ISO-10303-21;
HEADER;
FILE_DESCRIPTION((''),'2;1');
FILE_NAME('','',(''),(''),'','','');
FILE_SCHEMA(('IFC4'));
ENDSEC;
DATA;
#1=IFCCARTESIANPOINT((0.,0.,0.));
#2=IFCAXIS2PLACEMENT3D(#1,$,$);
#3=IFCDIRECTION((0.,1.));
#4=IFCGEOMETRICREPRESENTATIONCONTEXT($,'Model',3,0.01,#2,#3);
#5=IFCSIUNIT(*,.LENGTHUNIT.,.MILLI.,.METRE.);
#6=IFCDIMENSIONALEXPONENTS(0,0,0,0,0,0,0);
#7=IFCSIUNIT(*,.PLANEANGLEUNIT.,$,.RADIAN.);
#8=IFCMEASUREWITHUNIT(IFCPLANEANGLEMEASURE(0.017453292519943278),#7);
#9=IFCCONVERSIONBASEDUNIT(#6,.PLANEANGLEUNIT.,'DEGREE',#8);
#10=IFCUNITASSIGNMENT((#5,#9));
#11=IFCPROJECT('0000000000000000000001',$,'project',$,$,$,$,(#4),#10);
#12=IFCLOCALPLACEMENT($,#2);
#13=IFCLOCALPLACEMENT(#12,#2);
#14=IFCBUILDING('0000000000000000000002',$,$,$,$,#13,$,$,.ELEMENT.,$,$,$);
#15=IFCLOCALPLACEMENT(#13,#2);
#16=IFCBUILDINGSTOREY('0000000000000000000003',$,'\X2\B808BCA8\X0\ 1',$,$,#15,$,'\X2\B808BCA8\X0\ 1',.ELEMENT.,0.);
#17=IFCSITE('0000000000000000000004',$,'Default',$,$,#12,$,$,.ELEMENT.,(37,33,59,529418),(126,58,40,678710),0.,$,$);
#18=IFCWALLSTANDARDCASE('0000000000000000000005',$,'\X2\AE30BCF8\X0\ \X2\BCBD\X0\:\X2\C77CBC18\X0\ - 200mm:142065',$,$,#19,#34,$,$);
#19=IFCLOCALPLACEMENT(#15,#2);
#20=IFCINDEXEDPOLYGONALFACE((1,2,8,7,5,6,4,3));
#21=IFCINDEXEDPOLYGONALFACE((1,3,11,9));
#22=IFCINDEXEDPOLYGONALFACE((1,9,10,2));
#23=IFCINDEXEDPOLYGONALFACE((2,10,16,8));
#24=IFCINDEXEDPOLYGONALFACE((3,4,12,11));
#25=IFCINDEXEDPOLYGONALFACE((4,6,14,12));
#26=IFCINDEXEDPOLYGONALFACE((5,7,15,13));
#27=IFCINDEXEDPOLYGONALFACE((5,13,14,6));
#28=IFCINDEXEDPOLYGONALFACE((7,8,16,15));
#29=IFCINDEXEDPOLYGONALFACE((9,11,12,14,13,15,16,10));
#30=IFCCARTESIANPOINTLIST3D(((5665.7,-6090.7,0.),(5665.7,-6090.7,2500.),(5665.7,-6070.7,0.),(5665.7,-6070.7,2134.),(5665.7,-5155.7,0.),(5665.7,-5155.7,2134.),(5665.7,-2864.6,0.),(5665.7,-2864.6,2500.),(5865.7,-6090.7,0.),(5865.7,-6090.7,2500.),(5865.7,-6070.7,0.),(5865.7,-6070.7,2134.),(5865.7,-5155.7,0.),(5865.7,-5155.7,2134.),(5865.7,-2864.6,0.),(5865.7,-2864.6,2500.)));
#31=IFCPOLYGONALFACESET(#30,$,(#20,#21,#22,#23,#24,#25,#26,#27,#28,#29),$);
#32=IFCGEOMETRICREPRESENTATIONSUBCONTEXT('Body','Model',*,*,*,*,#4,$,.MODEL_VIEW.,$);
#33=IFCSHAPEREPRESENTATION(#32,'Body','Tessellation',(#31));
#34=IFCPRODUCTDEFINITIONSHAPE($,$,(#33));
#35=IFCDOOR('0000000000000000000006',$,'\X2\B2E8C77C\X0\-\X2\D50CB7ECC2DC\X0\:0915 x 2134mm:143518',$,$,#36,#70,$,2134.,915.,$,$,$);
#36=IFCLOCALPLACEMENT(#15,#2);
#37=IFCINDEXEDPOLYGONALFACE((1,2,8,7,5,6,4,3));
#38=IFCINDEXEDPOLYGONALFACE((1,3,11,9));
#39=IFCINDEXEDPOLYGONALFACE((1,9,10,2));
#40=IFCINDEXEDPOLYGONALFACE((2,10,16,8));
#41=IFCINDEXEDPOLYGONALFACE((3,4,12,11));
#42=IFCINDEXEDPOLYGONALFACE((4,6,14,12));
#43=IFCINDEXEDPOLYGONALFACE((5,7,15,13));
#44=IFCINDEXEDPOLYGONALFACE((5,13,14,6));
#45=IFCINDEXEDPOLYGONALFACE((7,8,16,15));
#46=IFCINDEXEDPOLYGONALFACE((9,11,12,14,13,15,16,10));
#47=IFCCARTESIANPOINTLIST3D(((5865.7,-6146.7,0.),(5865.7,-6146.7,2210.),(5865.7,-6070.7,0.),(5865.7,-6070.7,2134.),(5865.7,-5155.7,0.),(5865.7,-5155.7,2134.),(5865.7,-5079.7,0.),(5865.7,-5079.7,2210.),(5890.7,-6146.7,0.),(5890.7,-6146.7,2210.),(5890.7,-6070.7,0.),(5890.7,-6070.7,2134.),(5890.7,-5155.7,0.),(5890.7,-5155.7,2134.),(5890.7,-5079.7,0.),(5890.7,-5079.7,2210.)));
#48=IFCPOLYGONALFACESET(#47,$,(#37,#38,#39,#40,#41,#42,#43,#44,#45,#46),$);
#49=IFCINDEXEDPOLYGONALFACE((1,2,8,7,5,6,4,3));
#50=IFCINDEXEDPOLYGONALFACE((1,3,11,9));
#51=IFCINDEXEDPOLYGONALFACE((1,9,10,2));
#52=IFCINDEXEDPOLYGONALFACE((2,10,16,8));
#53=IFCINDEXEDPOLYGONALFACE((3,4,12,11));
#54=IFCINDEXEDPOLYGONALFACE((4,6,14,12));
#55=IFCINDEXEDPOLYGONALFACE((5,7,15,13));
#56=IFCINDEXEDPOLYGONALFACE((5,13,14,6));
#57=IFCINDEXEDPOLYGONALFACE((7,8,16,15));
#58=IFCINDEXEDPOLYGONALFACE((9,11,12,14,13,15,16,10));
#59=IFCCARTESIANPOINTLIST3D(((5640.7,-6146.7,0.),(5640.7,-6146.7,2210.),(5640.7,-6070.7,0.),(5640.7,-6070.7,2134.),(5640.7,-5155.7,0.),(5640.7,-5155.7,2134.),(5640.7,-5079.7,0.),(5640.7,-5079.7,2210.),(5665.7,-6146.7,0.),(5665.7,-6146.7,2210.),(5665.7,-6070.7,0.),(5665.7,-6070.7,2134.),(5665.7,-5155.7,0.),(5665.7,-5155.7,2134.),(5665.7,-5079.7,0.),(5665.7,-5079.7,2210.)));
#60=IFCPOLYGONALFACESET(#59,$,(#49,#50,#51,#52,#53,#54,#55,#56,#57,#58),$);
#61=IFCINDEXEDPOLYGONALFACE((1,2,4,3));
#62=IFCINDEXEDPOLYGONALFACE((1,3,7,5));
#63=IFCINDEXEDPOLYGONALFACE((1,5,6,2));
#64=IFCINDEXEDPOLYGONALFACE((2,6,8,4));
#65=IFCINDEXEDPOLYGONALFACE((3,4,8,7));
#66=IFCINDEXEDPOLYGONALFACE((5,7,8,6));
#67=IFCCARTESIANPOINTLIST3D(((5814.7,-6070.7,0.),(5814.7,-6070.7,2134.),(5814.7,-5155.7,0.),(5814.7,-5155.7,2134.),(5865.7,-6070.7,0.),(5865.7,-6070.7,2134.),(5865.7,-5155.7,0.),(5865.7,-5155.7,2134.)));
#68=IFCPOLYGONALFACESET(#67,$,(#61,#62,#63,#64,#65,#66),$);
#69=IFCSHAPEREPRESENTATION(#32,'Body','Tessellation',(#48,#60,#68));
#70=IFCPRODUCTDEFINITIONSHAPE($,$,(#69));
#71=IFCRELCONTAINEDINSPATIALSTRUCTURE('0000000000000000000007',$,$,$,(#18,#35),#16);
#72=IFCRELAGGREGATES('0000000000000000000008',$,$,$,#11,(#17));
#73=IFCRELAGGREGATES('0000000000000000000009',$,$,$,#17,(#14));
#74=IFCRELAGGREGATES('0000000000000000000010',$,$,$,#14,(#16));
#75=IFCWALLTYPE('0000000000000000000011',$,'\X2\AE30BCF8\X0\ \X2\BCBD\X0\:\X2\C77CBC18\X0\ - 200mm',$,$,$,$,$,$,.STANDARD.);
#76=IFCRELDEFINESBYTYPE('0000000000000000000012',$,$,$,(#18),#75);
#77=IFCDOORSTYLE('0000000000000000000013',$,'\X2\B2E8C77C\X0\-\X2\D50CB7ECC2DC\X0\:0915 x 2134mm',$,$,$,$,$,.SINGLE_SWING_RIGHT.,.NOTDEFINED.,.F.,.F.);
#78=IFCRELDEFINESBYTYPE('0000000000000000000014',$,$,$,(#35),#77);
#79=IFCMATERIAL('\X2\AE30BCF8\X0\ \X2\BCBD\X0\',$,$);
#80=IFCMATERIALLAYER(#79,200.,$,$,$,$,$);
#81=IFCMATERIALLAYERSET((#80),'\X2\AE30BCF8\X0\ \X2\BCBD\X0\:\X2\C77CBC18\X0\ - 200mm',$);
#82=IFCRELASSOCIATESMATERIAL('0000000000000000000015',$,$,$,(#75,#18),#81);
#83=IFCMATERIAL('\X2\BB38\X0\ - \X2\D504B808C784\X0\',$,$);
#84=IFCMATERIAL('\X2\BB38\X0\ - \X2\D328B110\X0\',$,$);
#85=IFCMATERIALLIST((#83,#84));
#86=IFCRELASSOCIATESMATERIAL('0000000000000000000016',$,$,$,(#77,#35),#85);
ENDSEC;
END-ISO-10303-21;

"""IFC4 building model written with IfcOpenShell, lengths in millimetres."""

from ifc_helpers import new_model, entity, si_unit, converted_unit, direction, frame, frame_2d, origin, place, context, subcontext, project, spatial, polyline, rectangle, outline, extrude, source, transform, mapped, material, material_list, layer, layer_set, layer_usage, type_object, type_shapes, element, fill, save


model = new_model("IFC4")

# Units and contexts
model_context = context("Model", 3, precision=0.01, world=origin(), true_north=direction((0.0, 1.0)))
body_context = subcontext(model_context, "Body", "Model", "MODEL_VIEW")
ifc_project = project(units=[si_unit("LENGTHUNIT", "METRE", prefix="MILLI"), converted_unit("PLANEANGLEUNIT", "DEGREE", entity("IfcPlaneAngleMeasure", 0.017453292519943278), si_unit("PLANEANGLEUNIT", "RADIAN"), dimensions=[0, 0, 0, 0, 0, 0, 0])], contexts=[model_context])

# Site, building, storey
site_placement = place(None, origin())
site = spatial("IfcSite", under=ifc_project, at=site_placement, Name="Default", CompositionType="ELEMENT", RefLatitude=(37, 33, 59, 529418), RefLongitude=(126, 58, 40, 678710), RefElevation=0.0)
building_placement = place(site_placement, origin())
building = spatial("IfcBuilding", under=site, at=building_placement, CompositionType="ELEMENT")
storey_placement = place(building_placement, origin())
storey = spatial("IfcBuildingStorey", under=building, at=storey_placement, Name="레벨 1", LongName="레벨 1", CompositionType="ELEMENT", Elevation=0.0)

# Shared definitions
ifc_material_1 = material(Name="기본 벽")
ifc_layer = layer(ifc_material_1, 200.0)
ifc_layer_set = layer_set([ifc_layer], Name="기본 벽:일반 - 200mm")
wall_type = type_object("IfcWallType", Name="기본 벽:일반 - 200mm", PredefinedType="STANDARD", material=ifc_layer_set)

# Wall, opening, door
ifc_layer_usage_1 = layer_usage(ifc_layer_set, "AXIS2", "NEGATIVE", 100.0)
wall_1_placement = place(storey_placement, frame((5765.7, -2864.6, 0.0), z_axis=(0.0, 0.0, 1.0), x_axis=(0.0, -1.0, 0.0)))
wall_1 = element("IfcWallStandardCase", 1, at=wall_1_placement, inside=storey, type_object=wall_type, material=ifc_layer_usage_1, Name="기본 벽:일반 - 200mm:142065", context=body_context, shape_type="SweptSolid", body=[
    extrude(rectangle(XDim=3226.1, YDim=200.0, at=frame_2d((1613.1, 0.0), x_axis=(-1.0, 0.0))), origin(), (0.0, 0.0, 1.0), 2500.0),
])
opening_1_placement = place(wall_1_placement, frame((2291.1, -100.0, 0.0)))
opening_1 = element("IfcOpeningElement", 2, at=opening_1_placement, cuts=wall_1, ObjectType="Opening", context=body_context, shape_type="SweptSolid", body=[
    extrude(rectangle(XDim=915.0, YDim=2134.0, at=frame_2d((1067.0, 457.5), x_axis=(0.0, 1.0))), frame((0.0, 0.0, 0.0), z_axis=(0.0, 1.0, 0.0), x_axis=(0.0, 0.0, 1.0)), (0.0, 0.0, 1.0), 200.0),
])
ifc_material_2 = material(Name="문 - 프레임")
ifc_material_3 = material(Name="문 - 패널")
ifc_material_list_1 = material_list([ifc_material_2, ifc_material_3])
door_style_1 = type_object("IfcDoorStyle", Name="단일-플러시:0915 x 2134mm", ConstructionType="NOTDEFINED", OperationType="SINGLE_SWING_RIGHT", ParameterTakesPrecedence=False, Sizeable=False, material=ifc_material_list_1)
shared_shape_1 = source(origin(), body_context, "Body", "SweptSolid", [
    extrude(outline(polyline([(-533.5, -1124.0), (533.5, -1124.0), (533.5, 1086.0), (457.5, 1086.0), (457.5, -1048.0), (-457.5, -1048.0), (-457.5, 1086.0), (-533.5, 1086.0), (-533.5, -1124.0)])), frame((457.5, 200.0, 1086.0), z_axis=(0.0, 1.0, 0.0), x_axis=(1.0, 0.0, 0.0)), (0.0, 0.0, 1.0), 25.0),
    extrude(outline(polyline([(-1124.0, -533.5), (1086.0, -533.5), (1086.0, -457.5), (-1048.0, -457.5), (-1048.0, 457.5), (1086.0, 457.5), (1086.0, 533.5), (-1124.0, 533.5), (-1124.0, -533.5)])), frame((457.5, -25.0, 1086.0), z_axis=(0.0, 1.0, 0.0), x_axis=(0.0, 0.0, -1.0)), (0.0, 0.0, 1.0), 25.0),
    extrude(rectangle(XDim=51.0, YDim=915.0, at=frame_2d((0.0, 0.0), x_axis=(1.0, 0.0))), frame((457.5, 174.5, 0.0), z_axis=(0.0, 0.0, 1.0), x_axis=(0.0, 1.0, 0.0)), (0.0, 0.0, 1.0), 2134.0),
])
type_shapes(door_style_1, [shared_shape_1])
door_1_placement = place(opening_1_placement, origin())
door_1 = element("IfcDoor", 3, at=door_1_placement, inside=storey, type_object=door_style_1, material=ifc_material_list_1, Name="단일-플러시:0915 x 2134mm:143518", OverallHeight=2134.0, OverallWidth=915.0, context=body_context, shape_type="MappedRepresentation", body=[
    mapped(shared_shape_1, transform((0.0, 0.0, 0.0), scale=1.0)),
])
fill(opening_1, door_1)

save(model, "model.ifc")
